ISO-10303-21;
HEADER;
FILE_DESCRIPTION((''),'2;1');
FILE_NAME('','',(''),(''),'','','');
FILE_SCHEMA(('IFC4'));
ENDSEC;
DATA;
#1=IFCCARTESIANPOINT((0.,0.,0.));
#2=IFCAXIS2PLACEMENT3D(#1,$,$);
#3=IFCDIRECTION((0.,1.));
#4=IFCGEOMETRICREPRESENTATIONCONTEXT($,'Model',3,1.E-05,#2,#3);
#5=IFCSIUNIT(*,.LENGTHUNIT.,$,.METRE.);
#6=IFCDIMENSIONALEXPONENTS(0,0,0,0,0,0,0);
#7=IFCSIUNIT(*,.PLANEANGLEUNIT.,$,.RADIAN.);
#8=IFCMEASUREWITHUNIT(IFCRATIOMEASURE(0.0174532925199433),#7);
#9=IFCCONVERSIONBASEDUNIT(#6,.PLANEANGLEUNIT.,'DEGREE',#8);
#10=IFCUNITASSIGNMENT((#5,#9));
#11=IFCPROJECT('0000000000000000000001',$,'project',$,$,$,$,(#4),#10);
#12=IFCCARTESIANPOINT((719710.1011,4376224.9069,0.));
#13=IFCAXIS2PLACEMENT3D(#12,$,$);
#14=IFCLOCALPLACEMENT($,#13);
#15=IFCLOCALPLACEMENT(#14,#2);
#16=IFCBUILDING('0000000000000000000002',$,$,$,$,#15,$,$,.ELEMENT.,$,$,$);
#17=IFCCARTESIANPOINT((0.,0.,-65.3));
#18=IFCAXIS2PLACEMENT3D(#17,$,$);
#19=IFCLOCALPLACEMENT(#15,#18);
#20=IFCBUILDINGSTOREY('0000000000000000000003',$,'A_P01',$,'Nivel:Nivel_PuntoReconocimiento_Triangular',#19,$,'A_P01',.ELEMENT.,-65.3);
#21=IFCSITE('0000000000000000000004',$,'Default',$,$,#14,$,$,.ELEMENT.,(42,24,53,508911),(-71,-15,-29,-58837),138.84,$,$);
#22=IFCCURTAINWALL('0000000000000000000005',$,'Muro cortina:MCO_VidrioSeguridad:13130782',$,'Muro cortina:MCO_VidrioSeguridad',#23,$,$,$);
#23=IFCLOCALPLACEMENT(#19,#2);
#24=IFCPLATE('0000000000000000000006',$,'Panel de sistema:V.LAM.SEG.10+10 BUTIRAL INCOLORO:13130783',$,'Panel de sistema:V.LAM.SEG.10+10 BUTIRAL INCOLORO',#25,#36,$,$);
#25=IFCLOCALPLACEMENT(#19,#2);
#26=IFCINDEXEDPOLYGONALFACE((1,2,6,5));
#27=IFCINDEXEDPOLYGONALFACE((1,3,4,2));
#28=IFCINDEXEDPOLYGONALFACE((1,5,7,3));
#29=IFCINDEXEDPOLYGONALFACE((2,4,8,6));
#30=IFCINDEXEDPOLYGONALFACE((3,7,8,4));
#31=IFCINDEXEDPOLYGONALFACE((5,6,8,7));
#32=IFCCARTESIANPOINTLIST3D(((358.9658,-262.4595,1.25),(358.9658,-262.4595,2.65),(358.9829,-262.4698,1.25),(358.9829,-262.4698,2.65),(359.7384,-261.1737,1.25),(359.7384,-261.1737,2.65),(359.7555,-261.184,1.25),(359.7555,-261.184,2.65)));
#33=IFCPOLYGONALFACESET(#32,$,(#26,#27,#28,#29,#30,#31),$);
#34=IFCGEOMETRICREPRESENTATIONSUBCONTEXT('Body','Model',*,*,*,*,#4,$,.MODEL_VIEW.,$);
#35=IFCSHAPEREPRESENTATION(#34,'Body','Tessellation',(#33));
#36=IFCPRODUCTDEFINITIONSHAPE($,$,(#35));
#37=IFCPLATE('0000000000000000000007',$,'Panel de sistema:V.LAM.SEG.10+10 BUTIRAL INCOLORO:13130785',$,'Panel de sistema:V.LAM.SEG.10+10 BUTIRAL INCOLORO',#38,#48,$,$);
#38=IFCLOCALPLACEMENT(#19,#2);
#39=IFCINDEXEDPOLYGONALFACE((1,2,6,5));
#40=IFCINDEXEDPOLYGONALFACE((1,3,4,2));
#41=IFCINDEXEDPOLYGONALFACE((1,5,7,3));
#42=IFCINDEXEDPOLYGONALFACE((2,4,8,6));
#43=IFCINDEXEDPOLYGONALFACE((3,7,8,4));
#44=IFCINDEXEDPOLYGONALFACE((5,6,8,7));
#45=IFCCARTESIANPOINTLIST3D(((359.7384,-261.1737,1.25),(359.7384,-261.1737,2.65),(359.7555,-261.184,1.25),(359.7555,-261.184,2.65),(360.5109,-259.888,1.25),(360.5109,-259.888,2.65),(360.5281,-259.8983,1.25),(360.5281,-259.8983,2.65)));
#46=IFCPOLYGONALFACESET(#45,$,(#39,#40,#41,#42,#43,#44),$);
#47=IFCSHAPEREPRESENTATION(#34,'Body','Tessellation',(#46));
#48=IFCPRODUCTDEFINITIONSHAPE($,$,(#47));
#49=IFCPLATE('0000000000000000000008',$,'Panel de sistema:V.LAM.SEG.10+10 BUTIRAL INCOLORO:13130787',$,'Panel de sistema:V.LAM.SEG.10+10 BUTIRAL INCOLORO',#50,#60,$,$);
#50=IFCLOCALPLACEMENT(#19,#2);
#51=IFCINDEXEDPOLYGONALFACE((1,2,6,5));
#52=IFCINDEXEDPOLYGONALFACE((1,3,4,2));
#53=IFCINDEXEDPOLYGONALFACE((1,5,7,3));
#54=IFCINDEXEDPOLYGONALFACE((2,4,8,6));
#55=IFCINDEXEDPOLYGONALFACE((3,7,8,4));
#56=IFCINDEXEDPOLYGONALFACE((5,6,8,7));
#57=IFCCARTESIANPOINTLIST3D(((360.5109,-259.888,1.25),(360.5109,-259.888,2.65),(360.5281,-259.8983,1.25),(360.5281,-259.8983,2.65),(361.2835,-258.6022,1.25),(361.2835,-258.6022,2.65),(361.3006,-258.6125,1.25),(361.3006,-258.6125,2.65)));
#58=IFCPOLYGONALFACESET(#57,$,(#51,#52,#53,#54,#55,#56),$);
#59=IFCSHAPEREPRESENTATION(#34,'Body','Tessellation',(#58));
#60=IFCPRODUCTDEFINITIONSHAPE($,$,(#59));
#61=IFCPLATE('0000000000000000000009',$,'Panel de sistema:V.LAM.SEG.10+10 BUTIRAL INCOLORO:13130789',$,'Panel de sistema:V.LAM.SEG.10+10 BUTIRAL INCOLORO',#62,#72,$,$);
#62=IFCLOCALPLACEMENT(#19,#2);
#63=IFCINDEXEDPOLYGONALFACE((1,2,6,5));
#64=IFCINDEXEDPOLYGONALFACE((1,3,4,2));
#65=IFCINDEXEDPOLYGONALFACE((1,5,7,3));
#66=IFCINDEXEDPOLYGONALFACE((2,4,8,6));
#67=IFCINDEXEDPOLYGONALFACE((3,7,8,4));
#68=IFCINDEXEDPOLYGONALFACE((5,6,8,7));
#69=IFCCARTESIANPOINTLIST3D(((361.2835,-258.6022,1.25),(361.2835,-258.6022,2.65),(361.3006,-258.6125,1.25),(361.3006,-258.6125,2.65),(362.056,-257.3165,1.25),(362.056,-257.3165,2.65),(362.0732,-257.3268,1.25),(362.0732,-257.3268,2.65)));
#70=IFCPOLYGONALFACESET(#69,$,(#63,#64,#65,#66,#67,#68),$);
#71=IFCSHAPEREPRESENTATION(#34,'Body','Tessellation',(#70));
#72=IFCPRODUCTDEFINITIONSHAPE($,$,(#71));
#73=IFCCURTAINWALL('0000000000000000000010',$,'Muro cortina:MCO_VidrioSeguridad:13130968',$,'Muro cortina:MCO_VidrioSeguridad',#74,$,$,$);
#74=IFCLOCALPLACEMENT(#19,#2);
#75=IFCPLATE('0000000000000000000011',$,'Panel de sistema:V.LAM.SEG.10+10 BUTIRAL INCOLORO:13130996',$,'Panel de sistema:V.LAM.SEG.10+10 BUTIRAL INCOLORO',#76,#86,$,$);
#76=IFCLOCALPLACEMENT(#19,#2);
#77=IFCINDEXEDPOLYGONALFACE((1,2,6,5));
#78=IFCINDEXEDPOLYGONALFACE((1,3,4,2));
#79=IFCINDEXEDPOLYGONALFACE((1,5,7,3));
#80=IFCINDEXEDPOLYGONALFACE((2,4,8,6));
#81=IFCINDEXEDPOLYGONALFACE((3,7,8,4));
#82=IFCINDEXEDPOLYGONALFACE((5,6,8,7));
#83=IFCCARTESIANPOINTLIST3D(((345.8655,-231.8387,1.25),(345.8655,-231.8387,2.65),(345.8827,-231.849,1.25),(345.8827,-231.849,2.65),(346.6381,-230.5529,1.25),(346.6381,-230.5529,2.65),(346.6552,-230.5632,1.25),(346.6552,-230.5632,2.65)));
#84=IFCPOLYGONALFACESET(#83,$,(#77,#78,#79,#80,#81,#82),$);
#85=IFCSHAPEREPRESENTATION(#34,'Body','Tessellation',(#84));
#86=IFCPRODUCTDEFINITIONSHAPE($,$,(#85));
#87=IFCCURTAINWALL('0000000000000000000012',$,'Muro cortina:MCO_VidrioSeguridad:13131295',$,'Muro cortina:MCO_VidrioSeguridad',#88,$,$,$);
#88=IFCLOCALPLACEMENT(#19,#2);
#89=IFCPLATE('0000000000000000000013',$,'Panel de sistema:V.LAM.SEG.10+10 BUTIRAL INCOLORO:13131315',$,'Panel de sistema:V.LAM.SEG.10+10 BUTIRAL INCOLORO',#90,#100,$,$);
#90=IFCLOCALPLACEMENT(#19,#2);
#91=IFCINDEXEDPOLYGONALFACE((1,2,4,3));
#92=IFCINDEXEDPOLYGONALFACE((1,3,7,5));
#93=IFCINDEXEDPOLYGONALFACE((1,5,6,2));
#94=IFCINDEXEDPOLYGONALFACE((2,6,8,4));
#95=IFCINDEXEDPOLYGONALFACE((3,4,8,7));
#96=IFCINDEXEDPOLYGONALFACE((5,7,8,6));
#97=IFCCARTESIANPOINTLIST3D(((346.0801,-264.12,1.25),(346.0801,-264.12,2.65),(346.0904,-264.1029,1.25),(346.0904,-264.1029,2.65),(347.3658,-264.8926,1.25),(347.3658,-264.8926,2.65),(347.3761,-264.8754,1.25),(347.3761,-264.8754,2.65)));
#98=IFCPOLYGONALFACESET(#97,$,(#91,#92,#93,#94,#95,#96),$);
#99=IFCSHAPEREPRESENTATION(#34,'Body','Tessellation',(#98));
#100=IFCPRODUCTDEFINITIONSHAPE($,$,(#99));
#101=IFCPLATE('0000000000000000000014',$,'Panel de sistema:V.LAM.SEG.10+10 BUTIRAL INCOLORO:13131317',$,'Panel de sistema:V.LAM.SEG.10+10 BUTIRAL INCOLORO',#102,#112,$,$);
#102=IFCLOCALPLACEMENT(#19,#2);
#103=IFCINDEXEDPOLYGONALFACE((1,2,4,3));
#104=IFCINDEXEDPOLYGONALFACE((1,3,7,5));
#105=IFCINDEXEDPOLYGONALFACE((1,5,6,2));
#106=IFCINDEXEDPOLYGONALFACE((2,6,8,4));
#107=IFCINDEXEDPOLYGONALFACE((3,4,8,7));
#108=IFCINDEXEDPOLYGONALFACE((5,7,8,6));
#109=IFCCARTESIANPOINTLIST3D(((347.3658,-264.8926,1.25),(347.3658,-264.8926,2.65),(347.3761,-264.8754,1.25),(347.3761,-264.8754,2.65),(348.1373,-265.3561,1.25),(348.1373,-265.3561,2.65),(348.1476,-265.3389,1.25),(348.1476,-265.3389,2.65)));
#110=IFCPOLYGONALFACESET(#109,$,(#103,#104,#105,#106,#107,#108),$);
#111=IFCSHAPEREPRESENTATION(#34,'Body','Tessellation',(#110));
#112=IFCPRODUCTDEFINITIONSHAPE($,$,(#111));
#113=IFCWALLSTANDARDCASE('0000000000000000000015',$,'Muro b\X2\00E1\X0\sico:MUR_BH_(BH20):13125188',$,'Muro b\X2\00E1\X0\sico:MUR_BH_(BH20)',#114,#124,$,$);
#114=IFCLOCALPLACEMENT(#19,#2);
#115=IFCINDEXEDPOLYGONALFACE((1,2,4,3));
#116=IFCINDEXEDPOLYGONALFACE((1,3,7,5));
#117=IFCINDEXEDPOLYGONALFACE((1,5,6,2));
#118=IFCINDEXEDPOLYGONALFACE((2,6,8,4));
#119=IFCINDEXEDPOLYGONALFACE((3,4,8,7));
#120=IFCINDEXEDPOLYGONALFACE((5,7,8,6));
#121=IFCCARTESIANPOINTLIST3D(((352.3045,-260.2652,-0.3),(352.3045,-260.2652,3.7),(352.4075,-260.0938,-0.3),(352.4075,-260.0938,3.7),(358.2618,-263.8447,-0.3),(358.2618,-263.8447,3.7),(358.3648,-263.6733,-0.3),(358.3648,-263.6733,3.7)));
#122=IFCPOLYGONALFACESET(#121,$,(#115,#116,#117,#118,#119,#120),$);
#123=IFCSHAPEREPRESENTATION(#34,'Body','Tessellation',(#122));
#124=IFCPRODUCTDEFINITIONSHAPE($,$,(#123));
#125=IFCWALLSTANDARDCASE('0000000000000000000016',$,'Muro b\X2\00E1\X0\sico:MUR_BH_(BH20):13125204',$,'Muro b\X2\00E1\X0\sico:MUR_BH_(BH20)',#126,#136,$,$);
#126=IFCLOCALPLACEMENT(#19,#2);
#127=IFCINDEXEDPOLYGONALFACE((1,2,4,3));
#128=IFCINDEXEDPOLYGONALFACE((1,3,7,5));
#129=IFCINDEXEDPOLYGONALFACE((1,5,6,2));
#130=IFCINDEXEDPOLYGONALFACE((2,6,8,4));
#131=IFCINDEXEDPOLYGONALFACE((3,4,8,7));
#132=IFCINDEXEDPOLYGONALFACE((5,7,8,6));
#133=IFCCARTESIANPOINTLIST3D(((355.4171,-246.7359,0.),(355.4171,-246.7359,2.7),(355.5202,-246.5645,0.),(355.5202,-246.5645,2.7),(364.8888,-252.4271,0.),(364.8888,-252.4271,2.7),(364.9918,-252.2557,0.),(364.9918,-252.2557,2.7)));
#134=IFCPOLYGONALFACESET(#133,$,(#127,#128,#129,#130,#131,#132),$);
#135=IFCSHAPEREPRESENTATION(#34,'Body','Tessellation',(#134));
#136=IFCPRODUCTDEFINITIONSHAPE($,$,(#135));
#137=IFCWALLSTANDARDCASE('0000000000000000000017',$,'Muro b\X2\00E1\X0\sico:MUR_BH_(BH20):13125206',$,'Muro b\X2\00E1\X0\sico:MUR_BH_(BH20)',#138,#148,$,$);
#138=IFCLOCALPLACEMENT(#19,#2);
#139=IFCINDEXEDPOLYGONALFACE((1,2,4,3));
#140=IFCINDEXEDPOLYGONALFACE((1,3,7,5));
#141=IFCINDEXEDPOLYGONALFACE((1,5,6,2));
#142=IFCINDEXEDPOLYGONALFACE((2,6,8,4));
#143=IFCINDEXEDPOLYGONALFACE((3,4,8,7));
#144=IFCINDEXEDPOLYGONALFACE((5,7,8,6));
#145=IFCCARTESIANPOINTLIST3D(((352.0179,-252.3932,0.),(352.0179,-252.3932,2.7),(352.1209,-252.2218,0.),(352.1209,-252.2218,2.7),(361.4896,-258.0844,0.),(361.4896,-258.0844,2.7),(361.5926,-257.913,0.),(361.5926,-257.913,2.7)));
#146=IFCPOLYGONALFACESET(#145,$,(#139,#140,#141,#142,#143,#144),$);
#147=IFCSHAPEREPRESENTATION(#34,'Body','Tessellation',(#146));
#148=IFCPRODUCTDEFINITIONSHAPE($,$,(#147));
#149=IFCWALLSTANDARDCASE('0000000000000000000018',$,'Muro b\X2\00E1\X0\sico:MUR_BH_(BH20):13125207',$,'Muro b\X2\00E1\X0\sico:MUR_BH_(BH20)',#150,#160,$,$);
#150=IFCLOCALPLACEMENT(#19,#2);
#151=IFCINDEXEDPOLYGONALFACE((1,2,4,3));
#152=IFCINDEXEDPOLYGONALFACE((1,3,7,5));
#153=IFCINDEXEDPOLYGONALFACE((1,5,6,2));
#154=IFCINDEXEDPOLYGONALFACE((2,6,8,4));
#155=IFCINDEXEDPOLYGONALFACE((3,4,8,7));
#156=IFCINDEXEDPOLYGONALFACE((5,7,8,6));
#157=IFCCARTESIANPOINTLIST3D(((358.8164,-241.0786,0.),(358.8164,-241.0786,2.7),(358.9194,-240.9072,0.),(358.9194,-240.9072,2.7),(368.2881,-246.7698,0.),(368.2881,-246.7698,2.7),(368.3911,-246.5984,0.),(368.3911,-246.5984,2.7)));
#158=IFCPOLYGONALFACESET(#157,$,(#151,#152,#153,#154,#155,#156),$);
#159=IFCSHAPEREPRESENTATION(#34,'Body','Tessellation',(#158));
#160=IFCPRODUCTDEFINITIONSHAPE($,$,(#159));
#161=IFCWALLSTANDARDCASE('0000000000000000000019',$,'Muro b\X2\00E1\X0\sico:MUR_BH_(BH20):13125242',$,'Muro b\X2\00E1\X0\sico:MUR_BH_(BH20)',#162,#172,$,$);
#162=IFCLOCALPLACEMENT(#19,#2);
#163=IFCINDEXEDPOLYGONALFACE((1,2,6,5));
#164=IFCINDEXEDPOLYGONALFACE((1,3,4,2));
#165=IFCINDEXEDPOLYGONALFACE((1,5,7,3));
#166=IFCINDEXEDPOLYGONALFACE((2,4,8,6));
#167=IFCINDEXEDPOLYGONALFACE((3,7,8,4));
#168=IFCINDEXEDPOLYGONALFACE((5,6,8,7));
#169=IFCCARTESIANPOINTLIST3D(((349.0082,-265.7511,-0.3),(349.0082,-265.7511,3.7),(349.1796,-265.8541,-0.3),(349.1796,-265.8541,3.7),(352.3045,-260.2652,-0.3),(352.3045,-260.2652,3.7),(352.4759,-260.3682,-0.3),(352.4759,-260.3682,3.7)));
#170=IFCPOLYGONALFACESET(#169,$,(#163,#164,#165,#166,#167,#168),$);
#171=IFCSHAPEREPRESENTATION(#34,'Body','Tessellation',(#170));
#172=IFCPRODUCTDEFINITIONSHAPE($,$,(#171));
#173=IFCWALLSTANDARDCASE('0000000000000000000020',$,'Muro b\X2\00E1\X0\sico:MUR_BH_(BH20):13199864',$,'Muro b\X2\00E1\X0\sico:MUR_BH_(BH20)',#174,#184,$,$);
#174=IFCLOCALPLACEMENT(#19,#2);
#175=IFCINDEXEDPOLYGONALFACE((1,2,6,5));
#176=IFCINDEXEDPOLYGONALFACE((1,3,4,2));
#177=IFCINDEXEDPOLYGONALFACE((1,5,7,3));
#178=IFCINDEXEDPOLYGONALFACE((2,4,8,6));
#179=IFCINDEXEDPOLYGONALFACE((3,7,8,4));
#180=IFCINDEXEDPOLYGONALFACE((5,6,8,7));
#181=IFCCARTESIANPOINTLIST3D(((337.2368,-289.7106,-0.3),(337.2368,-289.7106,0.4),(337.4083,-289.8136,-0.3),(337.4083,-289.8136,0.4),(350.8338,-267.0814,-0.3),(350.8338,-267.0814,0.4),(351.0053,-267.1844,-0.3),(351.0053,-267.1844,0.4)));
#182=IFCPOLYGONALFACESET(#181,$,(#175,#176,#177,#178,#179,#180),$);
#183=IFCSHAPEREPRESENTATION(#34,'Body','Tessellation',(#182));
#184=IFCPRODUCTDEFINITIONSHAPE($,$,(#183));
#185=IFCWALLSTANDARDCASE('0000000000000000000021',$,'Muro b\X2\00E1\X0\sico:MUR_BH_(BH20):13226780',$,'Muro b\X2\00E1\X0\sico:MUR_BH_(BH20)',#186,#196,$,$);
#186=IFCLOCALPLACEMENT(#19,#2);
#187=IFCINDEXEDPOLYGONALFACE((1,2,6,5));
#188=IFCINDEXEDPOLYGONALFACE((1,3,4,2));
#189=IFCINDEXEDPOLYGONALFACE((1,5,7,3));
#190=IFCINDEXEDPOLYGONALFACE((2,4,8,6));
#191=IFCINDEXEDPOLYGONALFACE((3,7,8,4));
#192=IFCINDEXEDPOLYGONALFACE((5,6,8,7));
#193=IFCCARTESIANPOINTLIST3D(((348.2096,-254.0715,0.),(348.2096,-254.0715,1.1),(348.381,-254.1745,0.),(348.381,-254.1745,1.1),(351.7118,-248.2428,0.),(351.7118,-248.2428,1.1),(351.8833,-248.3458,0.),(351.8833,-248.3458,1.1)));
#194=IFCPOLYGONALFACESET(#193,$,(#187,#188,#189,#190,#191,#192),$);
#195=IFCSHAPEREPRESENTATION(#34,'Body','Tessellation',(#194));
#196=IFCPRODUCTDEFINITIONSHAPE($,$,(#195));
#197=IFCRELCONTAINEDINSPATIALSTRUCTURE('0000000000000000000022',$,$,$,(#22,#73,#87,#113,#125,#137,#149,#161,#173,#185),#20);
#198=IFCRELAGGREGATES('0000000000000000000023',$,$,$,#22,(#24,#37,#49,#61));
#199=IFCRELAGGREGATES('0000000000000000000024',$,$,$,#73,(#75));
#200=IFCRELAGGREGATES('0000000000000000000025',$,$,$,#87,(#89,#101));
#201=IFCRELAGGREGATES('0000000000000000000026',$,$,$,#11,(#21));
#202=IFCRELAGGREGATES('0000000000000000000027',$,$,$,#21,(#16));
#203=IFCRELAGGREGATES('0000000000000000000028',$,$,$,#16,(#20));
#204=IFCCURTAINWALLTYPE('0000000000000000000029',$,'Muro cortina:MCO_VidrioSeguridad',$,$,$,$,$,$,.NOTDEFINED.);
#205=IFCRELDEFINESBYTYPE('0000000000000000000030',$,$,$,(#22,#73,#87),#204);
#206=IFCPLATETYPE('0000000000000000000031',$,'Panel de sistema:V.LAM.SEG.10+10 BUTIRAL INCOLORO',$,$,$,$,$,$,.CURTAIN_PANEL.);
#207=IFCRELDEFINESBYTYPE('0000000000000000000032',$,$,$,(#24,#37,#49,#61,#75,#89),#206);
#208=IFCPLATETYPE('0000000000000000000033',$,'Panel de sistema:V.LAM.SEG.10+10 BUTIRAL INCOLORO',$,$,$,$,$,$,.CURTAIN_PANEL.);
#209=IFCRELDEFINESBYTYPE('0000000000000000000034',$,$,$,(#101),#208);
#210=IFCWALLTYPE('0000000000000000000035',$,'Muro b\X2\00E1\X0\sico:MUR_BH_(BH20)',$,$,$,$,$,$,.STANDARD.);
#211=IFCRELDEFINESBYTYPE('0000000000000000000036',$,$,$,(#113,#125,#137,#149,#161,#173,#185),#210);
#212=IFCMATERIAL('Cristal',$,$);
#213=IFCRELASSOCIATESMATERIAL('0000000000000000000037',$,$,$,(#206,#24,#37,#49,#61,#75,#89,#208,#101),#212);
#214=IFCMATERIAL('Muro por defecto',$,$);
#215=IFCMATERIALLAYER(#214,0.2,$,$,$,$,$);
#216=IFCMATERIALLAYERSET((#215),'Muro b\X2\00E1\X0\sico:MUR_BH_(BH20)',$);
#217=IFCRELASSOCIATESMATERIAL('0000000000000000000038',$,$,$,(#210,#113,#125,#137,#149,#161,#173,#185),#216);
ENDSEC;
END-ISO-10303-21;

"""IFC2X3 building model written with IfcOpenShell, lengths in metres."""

from ifc_helpers import new_model, entity, si_unit, converted_unit, direction, frame, frame_2d, origin, origin_2d_with_axis, place, context, subcontext, project, spatial, rectangle, extrude, source, transform, mapped, material, layer, layer_set, layer_usage, type_object, type_shapes, element, aggregate, save


model = new_model("IFC2X3")

# Units and contexts
model_context = context("Model", 3, precision=1e-05, world=origin(), true_north=direction((0.0, 1.0)))
body_context = subcontext(model_context, "Body", "Model", "MODEL_VIEW")
ifc_project = project(units=[si_unit("LENGTHUNIT", "METRE"), converted_unit("PLANEANGLEUNIT", "DEGREE", entity("IfcRatioMeasure", 0.0174532925199433), si_unit("PLANEANGLEUNIT", "RADIAN"), dimensions=[0, 0, 0, 0, 0, 0, 0])], contexts=[model_context])

# Site, building, storey
site_placement = place(None, frame((719710.1011, 4376224.9069, 0.0)))
site = spatial("IfcSite", under=ifc_project, at=site_placement, Name="Default", CompositionType="ELEMENT", RefLatitude=(42, 24, 53, 508911), RefLongitude=(-71, -15, -29, -58837), RefElevation=138.84)
building_placement = place(site_placement, origin())
building = spatial("IfcBuilding", under=site, at=building_placement, CompositionType="ELEMENT")
storey_placement = place(building_placement, frame((0.0, 0.0, -65.3)))
storey = spatial("IfcBuildingStorey", under=building, at=storey_placement, Name="A_P01", ObjectType="Nivel:Nivel_PuntoReconocimiento_Triangular", LongName="A_P01", CompositionType="ELEMENT", Elevation=-65.3)

# Curtain wall, plates
curtain_wall_type = type_object("IfcCurtainWallType", Name="Muro cortina:MCO_VidrioSeguridad", PredefinedType="NOTDEFINED")
curtain_wall_1_placement = place(storey_placement, frame((0.0, 0.0, 65.3)))
curtain_wall_1 = element("IfcCurtainWall", 1, at=curtain_wall_1_placement, inside=storey, type_object=curtain_wall_type, Name="Muro cortina:MCO_VidrioSeguridad:13130782", ObjectType="Muro cortina:MCO_VidrioSeguridad")
ifc_material_1 = material(Name="Cristal")
plate_type_1 = type_object("IfcPlateType", Name="Panel de sistema:V.LAM.SEG.10+10 BUTIRAL INCOLORO", PredefinedType="CURTAIN_PANEL", material=ifc_material_1)
shared_shape_1 = source(origin(), body_context, "Body", "SweptSolid", [
    extrude(rectangle(XDim=0.02, YDim=1.5, at=origin_2d_with_axis()), frame((0.0, 0.0, 0.0), z_axis=(0.0, 0.0, 1.0), x_axis=(0.0, 1.0, 0.0)), (0.0, 0.0, 1.0), 1.4),
])
type_shapes(plate_type_1, [shared_shape_1])
plate_1_placement = place(curtain_wall_1_placement, frame((359.3606, -261.8217, -64.05), z_axis=(0.0, 0.0, 1.0), x_axis=(0.515038, 0.857167, 0.0)))
plate_1 = element("IfcPlate", 2, at=plate_1_placement, type_object=plate_type_1, material=ifc_material_1, Name="Panel de sistema:V.LAM.SEG.10+10 BUTIRAL INCOLORO:13130783", ObjectType="Panel de sistema:V.LAM.SEG.10+10 BUTIRAL INCOLORO", context=body_context, shape_type="MappedRepresentation", body=[
    mapped(shared_shape_1, transform((0.0, 0.0, 0.0), scale=1.0)),
])
plate_2_placement = place(curtain_wall_1_placement, frame((360.1332, -260.536, -64.05), z_axis=(0.0, 0.0, 1.0), x_axis=(0.515038, 0.857167, 0.0)))
plate_2 = element("IfcPlate", 3, at=plate_2_placement, type_object=plate_type_1, material=ifc_material_1, Name="Panel de sistema:V.LAM.SEG.10+10 BUTIRAL INCOLORO:13130785", ObjectType="Panel de sistema:V.LAM.SEG.10+10 BUTIRAL INCOLORO", context=body_context, shape_type="MappedRepresentation", body=[
    mapped(shared_shape_1, transform((0.0, 0.0, 0.0), scale=1.0)),
])
plate_3_placement = place(curtain_wall_1_placement, frame((360.9058, -259.2502, -64.05), z_axis=(0.0, 0.0, 1.0), x_axis=(0.515038, 0.857167, 0.0)))
plate_3 = element("IfcPlate", 4, at=plate_3_placement, type_object=plate_type_1, material=ifc_material_1, Name="Panel de sistema:V.LAM.SEG.10+10 BUTIRAL INCOLORO:13130787", ObjectType="Panel de sistema:V.LAM.SEG.10+10 BUTIRAL INCOLORO", context=body_context, shape_type="MappedRepresentation", body=[
    mapped(shared_shape_1, transform((0.0, 0.0, 0.0), scale=1.0)),
])
plate_4_placement = place(curtain_wall_1_placement, frame((361.6783, -257.9645, -64.05), z_axis=(0.0, 0.0, 1.0), x_axis=(0.515038, 0.857167, 0.0)))
plate_4 = element("IfcPlate", 5, at=plate_4_placement, type_object=plate_type_1, material=ifc_material_1, Name="Panel de sistema:V.LAM.SEG.10+10 BUTIRAL INCOLORO:13130789", ObjectType="Panel de sistema:V.LAM.SEG.10+10 BUTIRAL INCOLORO", context=body_context, shape_type="MappedRepresentation", body=[
    mapped(shared_shape_1, transform((0.0, 0.0, 0.0), scale=1.0)),
])
aggregate(curtain_wall_1, [plate_1, plate_2, plate_3, plate_4])

# Curtain wall, plate
curtain_wall_2_placement = place(storey_placement, frame((0.0, 0.0, 65.3)))
curtain_wall_2 = element("IfcCurtainWall", 6, at=curtain_wall_2_placement, inside=storey, type_object=curtain_wall_type, Name="Muro cortina:MCO_VidrioSeguridad:13130968", ObjectType="Muro cortina:MCO_VidrioSeguridad")
plate_5_placement = place(curtain_wall_2_placement, frame((346.2604, -231.2009, -64.05), z_axis=(0.0, 0.0, 1.0), x_axis=(0.515038, 0.857167, 0.0)))
plate_5 = element("IfcPlate", 7, at=plate_5_placement, type_object=plate_type_1, material=ifc_material_1, Name="Panel de sistema:V.LAM.SEG.10+10 BUTIRAL INCOLORO:13130996", ObjectType="Panel de sistema:V.LAM.SEG.10+10 BUTIRAL INCOLORO", context=body_context, shape_type="MappedRepresentation", body=[
    mapped(shared_shape_1, transform((0.0, 0.0, 0.0), scale=1.0)),
])
aggregate(curtain_wall_2, [plate_5])

# Curtain wall, plates
curtain_wall_3_placement = place(storey_placement, frame((0.0, 0.0, 65.3)))
curtain_wall_3 = element("IfcCurtainWall", 8, at=curtain_wall_3_placement, inside=storey, type_object=curtain_wall_type, Name="Muro cortina:MCO_VidrioSeguridad:13131295", ObjectType="Muro cortina:MCO_VidrioSeguridad")
plate_6_placement = place(curtain_wall_3_placement, frame((346.7281, -264.4977, -64.05), z_axis=(0.0, 0.0, 1.0), x_axis=(0.857167, -0.515038, 0.0)))
plate_6 = element("IfcPlate", 9, at=plate_6_placement, type_object=plate_type_1, material=ifc_material_1, Name="Panel de sistema:V.LAM.SEG.10+10 BUTIRAL INCOLORO:13131315", ObjectType="Panel de sistema:V.LAM.SEG.10+10 BUTIRAL INCOLORO", context=body_context, shape_type="MappedRepresentation", body=[
    mapped(shared_shape_1, transform((0.0, 0.0, 0.0), scale=1.0)),
])
plate_type_2 = type_object("IfcPlateType", Name="Panel de sistema:V.LAM.SEG.10+10 BUTIRAL INCOLORO", PredefinedType="CURTAIN_PANEL", material=ifc_material_1)
shared_shape_2 = source(origin(), body_context, "Body", "SweptSolid", [
    extrude(rectangle(XDim=0.02, YDim=0.9, at=origin_2d_with_axis()), frame((0.0, 0.0, 0.0), z_axis=(0.0, 0.0, 1.0), x_axis=(0.0, 1.0, 0.0)), (0.0, 0.0, 1.0), 1.4),
])
type_shapes(plate_type_2, [shared_shape_2])
plate_7_placement = place(curtain_wall_3_placement, frame((347.7567, -265.1157, -64.05), z_axis=(0.0, 0.0, 1.0), x_axis=(0.857167, -0.515038, 0.0)))
plate_7 = element("IfcPlate", 10, at=plate_7_placement, type_object=plate_type_2, material=ifc_material_1, Name="Panel de sistema:V.LAM.SEG.10+10 BUTIRAL INCOLORO:13131317", ObjectType="Panel de sistema:V.LAM.SEG.10+10 BUTIRAL INCOLORO", context=body_context, shape_type="MappedRepresentation", body=[
    mapped(shared_shape_2, transform((0.0, 0.0, 0.0), scale=1.0)),
])
aggregate(curtain_wall_3, [plate_6, plate_7])

# Wall
ifc_material_2 = material(Name="Muro por defecto")
ifc_layer = layer(ifc_material_2, 0.2)
ifc_layer_set = layer_set([ifc_layer], Name="Muro básico:MUR_BH_(BH20)")
ifc_layer_usage_1 = layer_usage(ifc_layer_set, "AXIS2", "NEGATIVE", 0.1)
wall_type = type_object("IfcWallType", Name="Muro básico:MUR_BH_(BH20)", PredefinedType="STANDARD", material=ifc_layer_set)
wall_1_placement = place(storey_placement, frame((358.3133, -263.759, -0.3), z_axis=(0.0, 0.0, 1.0), x_axis=(-0.857167, 0.515038, 0.0)))
element("IfcWallStandardCase", 11, at=wall_1_placement, inside=storey, type_object=wall_type, material=ifc_layer_usage_1, Name="Muro básico:MUR_BH_(BH20):13125188", ObjectType="Muro básico:MUR_BH_(BH20)", context=body_context, shape_type="SweptSolid", body=[
    extrude(rectangle(XDim=6.95, YDim=0.2, at=frame_2d((3.475, 0.0), x_axis=(-1.0, 0.0))), origin(), (0.0, 0.0, 1.0), 4.0),
])

# Walls
ifc_layer_usage_2 = layer_usage(ifc_layer_set, "AXIS2", "NEGATIVE", 0.1)
wall_2_placement = place(storey_placement, frame((355.4686, -246.6502, 0.0), z_axis=(0.0, 0.0, 1.0), x_axis=(0.857167, -0.515038, 0.0)))
element("IfcWallStandardCase", 12, at=wall_2_placement, inside=storey, type_object=wall_type, material=ifc_layer_usage_2, Name="Muro básico:MUR_BH_(BH20):13125204", ObjectType="Muro básico:MUR_BH_(BH20)", context=body_context, shape_type="SweptSolid", body=[
    extrude(rectangle(XDim=11.05, YDim=0.2, at=frame_2d((5.525, 0.0), x_axis=(-1.0, 0.0))), origin(), (0.0, 0.0, 1.0), 2.7),
])
ifc_layer_usage_3 = layer_usage(ifc_layer_set, "AXIS2", "NEGATIVE", 0.1)
wall_3_placement = place(storey_placement, frame((352.0694, -252.3075, 0.0), z_axis=(0.0, 0.0, 1.0), x_axis=(0.857167, -0.515038, 0.0)))
element("IfcWallStandardCase", 13, at=wall_3_placement, inside=storey, type_object=wall_type, material=ifc_layer_usage_3, Name="Muro básico:MUR_BH_(BH20):13125206", ObjectType="Muro básico:MUR_BH_(BH20)", context=body_context, shape_type="SweptSolid", body=[
    extrude(rectangle(XDim=11.05, YDim=0.2, at=frame_2d((5.525, 0.0), x_axis=(-1.0, 0.0))), origin(), (0.0, 0.0, 1.0), 2.7),
])
ifc_layer_usage_4 = layer_usage(ifc_layer_set, "AXIS2", "NEGATIVE", 0.1)
wall_4_placement = place(storey_placement, frame((358.8679, -240.9929, 0.0), z_axis=(0.0, 0.0, 1.0), x_axis=(0.857167, -0.515038, 0.0)))
element("IfcWallStandardCase", 14, at=wall_4_placement, inside=storey, type_object=wall_type, material=ifc_layer_usage_4, Name="Muro básico:MUR_BH_(BH20):13125207", ObjectType="Muro básico:MUR_BH_(BH20)", context=body_context, shape_type="SweptSolid", body=[
    extrude(rectangle(XDim=11.05, YDim=0.2, at=frame_2d((5.525, 0.0), x_axis=(-1.0, 0.0))), origin(), (0.0, 0.0, 1.0), 2.7),
])
ifc_layer_usage_5 = layer_usage(ifc_layer_set, "AXIS2", "NEGATIVE", 0.1)
wall_5_placement = place(storey_placement, frame((352.3902, -260.3167, -0.3), z_axis=(0.0, 0.0, 1.0), x_axis=(-0.515038, -0.857167, 0.0)))
element("IfcWallStandardCase", 15, at=wall_5_placement, inside=storey, type_object=wall_type, material=ifc_layer_usage_5, Name="Muro básico:MUR_BH_(BH20):13125242", ObjectType="Muro básico:MUR_BH_(BH20)", context=body_context, shape_type="SweptSolid", body=[
    extrude(rectangle(XDim=6.4, YDim=0.2, at=frame_2d((3.2, 0.0), x_axis=(-1.0, 0.0))), origin(), (0.0, 0.0, 1.0), 4.0),
])
ifc_layer_usage_6 = layer_usage(ifc_layer_set, "AXIS2", "NEGATIVE", 0.1)
wall_6_placement = place(storey_placement, frame((350.9196, -267.1329, -0.3), z_axis=(0.0, 0.0, 1.0), x_axis=(-0.515038, -0.857167, 0.0)))
element("IfcWallStandardCase", 16, at=wall_6_placement, inside=storey, type_object=wall_type, material=ifc_layer_usage_6, Name="Muro básico:MUR_BH_(BH20):13199864", ObjectType="Muro básico:MUR_BH_(BH20)", context=body_context, shape_type="SweptSolid", body=[
    extrude(rectangle(XDim=26.4, YDim=0.2, at=frame_2d((13.2, 0.0), x_axis=(-1.0, 0.0))), origin(), (0.0, 0.0, 1.0), 0.7),
])
ifc_layer_usage_7 = layer_usage(ifc_layer_set, "AXIS2", "NEGATIVE", 0.1)
wall_7_placement = place(storey_placement, frame((348.2953, -254.123, 0.0), z_axis=(0.0, 0.0, 1.0), x_axis=(0.515038, 0.857167, 0.0)))
element("IfcWallStandardCase", 17, at=wall_7_placement, inside=storey, type_object=wall_type, material=ifc_layer_usage_7, Name="Muro básico:MUR_BH_(BH20):13226780", ObjectType="Muro básico:MUR_BH_(BH20)", context=body_context, shape_type="SweptSolid", body=[
    extrude(rectangle(XDim=6.8, YDim=0.2, at=frame_2d((3.4, 0.0), x_axis=(-1.0, 0.0))), origin(), (0.0, 0.0, 1.0), 1.1),
])

save(model, "model.ifc")
